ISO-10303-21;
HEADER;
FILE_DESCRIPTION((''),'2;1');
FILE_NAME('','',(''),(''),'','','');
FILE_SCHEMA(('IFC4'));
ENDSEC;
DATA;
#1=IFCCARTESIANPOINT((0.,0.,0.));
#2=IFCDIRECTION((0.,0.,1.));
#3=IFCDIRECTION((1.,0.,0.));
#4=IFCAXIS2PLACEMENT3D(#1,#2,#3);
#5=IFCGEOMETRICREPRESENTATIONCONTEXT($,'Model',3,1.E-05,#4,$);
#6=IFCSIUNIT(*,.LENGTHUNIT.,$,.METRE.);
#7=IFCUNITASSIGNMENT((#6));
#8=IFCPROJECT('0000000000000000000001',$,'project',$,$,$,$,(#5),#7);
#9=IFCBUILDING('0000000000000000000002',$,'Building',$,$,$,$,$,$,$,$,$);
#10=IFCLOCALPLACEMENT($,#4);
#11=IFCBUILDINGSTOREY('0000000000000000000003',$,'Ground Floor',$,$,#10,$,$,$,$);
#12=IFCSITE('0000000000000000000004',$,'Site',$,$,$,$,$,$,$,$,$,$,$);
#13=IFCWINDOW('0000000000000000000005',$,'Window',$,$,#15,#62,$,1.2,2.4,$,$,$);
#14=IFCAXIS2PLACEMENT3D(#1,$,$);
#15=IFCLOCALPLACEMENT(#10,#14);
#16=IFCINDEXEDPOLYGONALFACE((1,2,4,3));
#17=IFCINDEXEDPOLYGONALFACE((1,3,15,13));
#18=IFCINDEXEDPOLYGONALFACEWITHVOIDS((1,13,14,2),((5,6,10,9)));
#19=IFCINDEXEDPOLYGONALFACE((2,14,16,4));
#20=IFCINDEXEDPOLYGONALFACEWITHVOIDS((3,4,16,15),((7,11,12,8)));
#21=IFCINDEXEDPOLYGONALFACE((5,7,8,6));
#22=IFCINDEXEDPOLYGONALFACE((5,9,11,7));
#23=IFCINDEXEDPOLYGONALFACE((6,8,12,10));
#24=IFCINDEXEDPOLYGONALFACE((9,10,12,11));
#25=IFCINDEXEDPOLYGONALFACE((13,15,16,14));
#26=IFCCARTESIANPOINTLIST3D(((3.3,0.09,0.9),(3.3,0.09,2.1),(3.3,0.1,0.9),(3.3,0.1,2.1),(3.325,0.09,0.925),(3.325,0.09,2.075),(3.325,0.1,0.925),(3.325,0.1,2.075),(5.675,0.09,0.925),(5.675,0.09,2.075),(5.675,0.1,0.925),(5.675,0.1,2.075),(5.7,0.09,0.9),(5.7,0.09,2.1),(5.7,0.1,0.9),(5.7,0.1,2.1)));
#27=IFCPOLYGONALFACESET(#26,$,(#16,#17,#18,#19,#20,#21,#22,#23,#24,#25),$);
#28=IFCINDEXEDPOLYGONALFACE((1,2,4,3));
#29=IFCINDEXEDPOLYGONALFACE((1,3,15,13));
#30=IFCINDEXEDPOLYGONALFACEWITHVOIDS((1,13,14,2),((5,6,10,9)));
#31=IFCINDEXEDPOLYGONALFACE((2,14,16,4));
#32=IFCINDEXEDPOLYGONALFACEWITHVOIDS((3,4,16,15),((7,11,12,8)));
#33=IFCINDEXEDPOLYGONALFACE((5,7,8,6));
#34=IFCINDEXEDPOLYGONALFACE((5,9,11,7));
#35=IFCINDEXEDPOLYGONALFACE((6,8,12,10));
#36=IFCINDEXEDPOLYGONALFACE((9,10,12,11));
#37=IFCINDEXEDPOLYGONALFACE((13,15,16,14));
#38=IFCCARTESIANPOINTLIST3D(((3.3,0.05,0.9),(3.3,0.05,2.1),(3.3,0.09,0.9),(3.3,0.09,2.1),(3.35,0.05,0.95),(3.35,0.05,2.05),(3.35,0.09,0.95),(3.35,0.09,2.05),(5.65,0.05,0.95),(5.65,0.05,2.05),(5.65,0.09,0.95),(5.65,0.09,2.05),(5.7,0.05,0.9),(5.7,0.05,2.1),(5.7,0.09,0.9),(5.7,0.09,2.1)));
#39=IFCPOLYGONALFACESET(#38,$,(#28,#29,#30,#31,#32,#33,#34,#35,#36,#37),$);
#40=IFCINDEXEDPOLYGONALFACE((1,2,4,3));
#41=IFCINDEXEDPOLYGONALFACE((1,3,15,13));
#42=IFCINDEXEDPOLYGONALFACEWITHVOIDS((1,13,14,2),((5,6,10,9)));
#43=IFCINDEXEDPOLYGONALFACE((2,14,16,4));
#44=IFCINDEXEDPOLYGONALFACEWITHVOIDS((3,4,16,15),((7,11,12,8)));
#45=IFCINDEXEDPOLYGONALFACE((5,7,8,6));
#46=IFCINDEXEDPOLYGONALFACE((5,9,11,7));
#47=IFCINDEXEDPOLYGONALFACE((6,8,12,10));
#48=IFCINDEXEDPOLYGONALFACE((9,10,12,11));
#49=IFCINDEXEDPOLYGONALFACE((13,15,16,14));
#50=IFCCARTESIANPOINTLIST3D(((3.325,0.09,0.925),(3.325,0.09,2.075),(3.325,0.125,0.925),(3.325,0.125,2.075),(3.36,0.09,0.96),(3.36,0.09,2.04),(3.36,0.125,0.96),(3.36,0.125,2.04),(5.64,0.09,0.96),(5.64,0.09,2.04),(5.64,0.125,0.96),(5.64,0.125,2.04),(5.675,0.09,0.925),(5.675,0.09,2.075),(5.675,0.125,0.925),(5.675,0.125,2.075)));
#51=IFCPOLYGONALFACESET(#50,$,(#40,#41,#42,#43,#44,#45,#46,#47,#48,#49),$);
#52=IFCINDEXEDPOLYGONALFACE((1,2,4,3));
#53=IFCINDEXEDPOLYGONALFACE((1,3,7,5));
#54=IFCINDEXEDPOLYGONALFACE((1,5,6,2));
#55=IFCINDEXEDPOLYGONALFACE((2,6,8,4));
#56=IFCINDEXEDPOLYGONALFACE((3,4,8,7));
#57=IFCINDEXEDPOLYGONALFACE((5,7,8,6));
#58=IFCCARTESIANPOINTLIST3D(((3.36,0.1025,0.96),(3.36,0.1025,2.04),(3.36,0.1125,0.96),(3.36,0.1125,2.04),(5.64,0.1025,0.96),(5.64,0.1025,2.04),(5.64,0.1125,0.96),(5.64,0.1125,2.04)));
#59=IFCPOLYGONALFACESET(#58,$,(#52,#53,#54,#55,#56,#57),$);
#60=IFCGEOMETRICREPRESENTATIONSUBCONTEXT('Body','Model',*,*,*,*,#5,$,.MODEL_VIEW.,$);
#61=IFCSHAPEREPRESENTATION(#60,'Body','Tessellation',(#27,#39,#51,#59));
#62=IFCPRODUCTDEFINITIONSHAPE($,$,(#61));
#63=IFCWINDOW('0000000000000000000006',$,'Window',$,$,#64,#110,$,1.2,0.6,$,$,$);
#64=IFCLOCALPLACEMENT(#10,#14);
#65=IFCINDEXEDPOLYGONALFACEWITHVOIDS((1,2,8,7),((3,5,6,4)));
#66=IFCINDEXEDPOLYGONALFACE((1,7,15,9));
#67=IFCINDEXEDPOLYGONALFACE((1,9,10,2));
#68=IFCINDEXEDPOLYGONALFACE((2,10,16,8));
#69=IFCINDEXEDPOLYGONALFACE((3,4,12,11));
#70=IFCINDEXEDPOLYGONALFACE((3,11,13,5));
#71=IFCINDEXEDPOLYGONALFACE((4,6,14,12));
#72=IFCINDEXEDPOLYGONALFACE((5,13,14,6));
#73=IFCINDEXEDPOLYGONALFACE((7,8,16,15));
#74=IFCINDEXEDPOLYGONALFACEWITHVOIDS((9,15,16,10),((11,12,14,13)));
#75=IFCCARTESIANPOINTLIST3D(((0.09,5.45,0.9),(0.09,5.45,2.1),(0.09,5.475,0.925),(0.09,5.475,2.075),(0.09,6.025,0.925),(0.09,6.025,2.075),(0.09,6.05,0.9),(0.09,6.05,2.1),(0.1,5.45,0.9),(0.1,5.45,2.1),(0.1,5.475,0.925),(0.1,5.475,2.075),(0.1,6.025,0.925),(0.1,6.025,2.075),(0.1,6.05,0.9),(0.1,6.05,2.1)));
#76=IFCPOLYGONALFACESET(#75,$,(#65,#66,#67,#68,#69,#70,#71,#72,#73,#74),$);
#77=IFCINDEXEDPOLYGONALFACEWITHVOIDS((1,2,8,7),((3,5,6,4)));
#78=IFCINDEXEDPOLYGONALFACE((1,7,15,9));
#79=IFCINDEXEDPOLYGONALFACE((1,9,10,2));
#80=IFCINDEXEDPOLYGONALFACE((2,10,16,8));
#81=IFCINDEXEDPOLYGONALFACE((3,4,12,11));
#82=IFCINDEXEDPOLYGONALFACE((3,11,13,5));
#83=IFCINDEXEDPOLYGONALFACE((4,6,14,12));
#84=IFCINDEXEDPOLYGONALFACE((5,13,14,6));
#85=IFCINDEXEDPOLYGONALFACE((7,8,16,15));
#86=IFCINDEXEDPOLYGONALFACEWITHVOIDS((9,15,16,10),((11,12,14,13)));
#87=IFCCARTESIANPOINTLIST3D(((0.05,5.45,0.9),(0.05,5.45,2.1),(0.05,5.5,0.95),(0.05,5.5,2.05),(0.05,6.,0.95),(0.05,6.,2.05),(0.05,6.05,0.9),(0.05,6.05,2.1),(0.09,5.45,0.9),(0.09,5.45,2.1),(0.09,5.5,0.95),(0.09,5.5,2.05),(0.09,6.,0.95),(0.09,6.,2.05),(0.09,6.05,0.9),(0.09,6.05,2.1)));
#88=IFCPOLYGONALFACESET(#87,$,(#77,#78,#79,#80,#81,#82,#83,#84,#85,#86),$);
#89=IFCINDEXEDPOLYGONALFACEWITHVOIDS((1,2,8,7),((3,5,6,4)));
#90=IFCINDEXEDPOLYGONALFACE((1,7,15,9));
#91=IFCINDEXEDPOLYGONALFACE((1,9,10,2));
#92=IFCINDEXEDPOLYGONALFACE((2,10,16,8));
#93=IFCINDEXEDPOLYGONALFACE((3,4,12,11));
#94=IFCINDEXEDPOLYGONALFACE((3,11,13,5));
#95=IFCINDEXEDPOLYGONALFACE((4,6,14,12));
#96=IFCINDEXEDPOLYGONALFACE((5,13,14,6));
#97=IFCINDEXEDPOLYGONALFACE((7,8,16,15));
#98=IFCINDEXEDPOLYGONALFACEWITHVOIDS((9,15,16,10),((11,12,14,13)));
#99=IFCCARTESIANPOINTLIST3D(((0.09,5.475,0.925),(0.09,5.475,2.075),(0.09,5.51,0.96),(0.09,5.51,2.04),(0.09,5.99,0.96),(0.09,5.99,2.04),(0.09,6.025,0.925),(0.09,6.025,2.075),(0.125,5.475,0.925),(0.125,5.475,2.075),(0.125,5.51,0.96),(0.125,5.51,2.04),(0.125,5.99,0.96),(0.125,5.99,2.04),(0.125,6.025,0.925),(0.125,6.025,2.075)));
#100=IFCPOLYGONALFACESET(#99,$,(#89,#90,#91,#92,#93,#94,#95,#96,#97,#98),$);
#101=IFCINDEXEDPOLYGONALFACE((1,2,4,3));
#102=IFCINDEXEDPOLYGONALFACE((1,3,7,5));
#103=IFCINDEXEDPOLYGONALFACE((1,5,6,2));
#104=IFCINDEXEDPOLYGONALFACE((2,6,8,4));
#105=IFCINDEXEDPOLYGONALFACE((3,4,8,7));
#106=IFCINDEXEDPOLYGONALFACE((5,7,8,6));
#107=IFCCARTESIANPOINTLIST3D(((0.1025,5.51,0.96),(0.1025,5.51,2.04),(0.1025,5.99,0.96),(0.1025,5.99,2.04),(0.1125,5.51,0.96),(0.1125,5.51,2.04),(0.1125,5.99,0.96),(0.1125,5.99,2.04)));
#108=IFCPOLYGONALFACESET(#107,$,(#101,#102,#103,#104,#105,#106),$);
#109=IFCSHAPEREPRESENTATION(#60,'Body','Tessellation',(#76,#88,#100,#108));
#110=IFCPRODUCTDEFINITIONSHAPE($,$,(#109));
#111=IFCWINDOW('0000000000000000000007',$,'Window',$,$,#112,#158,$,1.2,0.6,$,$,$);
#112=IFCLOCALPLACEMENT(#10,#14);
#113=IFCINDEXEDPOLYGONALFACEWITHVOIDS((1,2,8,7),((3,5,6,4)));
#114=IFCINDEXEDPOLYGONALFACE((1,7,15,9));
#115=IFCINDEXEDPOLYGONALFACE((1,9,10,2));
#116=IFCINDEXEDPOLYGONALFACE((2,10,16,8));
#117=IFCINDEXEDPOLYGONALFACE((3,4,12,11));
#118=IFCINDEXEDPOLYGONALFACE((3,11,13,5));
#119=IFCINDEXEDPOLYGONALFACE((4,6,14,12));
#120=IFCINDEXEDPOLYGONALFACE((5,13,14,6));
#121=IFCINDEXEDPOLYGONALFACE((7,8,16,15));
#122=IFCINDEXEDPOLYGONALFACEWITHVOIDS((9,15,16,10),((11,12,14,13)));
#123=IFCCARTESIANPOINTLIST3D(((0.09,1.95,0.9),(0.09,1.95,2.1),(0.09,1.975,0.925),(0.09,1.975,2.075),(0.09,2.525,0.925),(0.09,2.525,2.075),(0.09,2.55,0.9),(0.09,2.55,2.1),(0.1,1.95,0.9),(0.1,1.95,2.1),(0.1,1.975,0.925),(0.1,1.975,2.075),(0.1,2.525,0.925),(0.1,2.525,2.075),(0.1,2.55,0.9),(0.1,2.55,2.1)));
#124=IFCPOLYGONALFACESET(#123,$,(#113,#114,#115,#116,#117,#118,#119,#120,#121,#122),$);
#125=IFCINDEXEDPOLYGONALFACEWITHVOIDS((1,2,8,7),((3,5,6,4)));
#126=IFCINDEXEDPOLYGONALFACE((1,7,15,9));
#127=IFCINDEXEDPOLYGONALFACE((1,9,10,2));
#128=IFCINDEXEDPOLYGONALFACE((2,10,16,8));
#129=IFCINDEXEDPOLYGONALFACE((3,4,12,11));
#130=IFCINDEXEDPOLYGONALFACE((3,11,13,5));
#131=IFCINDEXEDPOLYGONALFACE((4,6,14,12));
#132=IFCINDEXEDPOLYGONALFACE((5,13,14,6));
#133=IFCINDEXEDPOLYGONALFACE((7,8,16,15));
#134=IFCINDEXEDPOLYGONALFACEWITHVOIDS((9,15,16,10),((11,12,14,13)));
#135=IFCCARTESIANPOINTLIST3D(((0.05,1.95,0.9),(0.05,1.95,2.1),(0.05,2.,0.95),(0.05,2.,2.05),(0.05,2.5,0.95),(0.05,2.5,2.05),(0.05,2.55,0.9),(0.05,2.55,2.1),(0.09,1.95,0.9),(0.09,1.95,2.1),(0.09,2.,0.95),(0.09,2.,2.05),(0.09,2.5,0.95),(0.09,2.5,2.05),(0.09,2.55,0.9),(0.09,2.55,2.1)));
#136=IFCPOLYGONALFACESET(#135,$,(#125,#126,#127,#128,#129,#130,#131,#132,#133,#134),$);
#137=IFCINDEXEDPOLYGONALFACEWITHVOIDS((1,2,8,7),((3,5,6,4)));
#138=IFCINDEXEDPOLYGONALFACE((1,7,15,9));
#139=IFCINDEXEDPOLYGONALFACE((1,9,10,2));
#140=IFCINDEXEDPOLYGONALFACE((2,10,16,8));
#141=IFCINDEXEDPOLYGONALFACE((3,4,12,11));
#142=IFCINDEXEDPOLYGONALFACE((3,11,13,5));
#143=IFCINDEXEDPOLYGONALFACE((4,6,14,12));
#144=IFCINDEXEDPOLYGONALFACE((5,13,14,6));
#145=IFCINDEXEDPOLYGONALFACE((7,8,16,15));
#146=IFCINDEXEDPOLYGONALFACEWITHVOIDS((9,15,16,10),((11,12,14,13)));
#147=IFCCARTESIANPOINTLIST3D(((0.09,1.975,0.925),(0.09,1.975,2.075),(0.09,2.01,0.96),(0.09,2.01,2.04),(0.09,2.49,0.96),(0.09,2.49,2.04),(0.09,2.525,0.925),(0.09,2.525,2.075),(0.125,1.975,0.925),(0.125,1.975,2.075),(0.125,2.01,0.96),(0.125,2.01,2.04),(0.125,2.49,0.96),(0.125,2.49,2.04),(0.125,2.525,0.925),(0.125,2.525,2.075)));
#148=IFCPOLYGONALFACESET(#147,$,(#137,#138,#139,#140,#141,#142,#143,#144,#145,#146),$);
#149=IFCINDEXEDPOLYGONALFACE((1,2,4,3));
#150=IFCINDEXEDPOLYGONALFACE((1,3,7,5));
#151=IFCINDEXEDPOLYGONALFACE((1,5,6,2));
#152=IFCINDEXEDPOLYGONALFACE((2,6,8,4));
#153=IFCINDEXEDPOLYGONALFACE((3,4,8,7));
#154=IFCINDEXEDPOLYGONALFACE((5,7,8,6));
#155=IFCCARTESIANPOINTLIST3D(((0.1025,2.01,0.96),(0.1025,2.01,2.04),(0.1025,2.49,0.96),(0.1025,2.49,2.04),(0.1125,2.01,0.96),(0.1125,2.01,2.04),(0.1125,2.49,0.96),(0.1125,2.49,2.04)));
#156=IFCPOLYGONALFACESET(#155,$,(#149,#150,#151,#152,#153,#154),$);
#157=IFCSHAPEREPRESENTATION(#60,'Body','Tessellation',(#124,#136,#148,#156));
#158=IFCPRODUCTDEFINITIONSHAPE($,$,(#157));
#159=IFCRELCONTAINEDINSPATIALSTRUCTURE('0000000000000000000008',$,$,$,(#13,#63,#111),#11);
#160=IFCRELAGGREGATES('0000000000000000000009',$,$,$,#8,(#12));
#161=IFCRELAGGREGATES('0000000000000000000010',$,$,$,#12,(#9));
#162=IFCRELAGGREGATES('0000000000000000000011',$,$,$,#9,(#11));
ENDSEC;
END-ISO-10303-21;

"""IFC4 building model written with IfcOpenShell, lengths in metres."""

from ifc_helpers import new_model, si_unit, frame, origin_with_axes, place, context, subcontext, project, spatial, line, indexed_curve, outline, extrude, element, save


model = new_model("IFC4")

# Units and contexts
model_context = context("Model", 3, precision=1e-05, world=origin_with_axes())
body_context = subcontext(model_context, "Body", "Model", "MODEL_VIEW")
ifc_project = project(units=[si_unit("LENGTHUNIT", "METRE")], contexts=[model_context])

# Site, building, storey
site = spatial("IfcSite", under=ifc_project, Name="Site")
building = spatial("IfcBuilding", under=site, Name="Building")
storey_placement = place(None, origin_with_axes())
storey = spatial("IfcBuildingStorey", under=building, at=storey_placement, Name="Ground Floor")

# Windows
window_placement = place(storey_placement, frame((3.3, 0.0, 0.9), z_axis=(0.0, 0.0, 1.0), x_axis=(1.0, 0.0, 0.0)))
element("IfcWindow", 1, at=window_placement, inside=storey, Name="Window", OverallHeight=1.2, OverallWidth=2.4, context=body_context, shape_type="SweptSolid", body=[
    extrude(outline(indexed_curve([(0.0, 0.0), (2.4, 0.0), (2.4, 1.2), (0.0, 1.2)], segments=[line(1, 2, 3, 4, 1)]), holes=[indexed_curve([(0.025, 0.025), (2.375, 0.025), (2.375, 1.175), (0.025, 1.175)], segments=[line(1, 2, 3, 4, 1)])]), frame((0.0, 0.09, 0.0), z_axis=(0.0, -1.0, 0.0), x_axis=(1.0, 0.0, 0.0)), (0.0, 0.0, -1.0), 0.01),
    extrude(outline(indexed_curve([(0.0, 0.0), (2.4, 0.0), (2.4, 1.2), (0.0, 1.2)], segments=[line(1, 2, 3, 4, 1)]), holes=[indexed_curve([(0.05, 0.05), (2.35, 0.05), (2.35, 1.15), (0.05, 1.15)], segments=[line(1, 2, 3, 4, 1)])]), frame((0.0, 0.05, 0.0), z_axis=(0.0, -1.0, 0.0), x_axis=(1.0, 0.0, 0.0)), (0.0, 0.0, -1.0), 0.04),
    extrude(outline(indexed_curve([(0.0, 0.0), (2.35, 0.0), (2.35, 1.15), (0.0, 1.15)], segments=[line(1, 2, 3, 4, 1)]), holes=[indexed_curve([(0.035, 0.035), (2.315, 0.035), (2.315, 1.115), (0.035, 1.115)], segments=[line(1, 2, 3, 4, 1)])]), frame((0.025, 0.09, 0.025), z_axis=(0.0, -1.0, 0.0), x_axis=(1.0, 0.0, 0.0)), (0.0, 0.0, -1.0), 0.035),
    extrude(outline(indexed_curve([(0.035, 0.035), (2.315, 0.035), (2.315, 1.115), (0.035, 1.115)], segments=[line(1, 2, 3, 4, 1)])), frame((0.025, 0.1025, 0.025), z_axis=(0.0, -1.0, 0.0), x_axis=(1.0, 0.0, 0.0)), (0.0, 0.0, -1.0), 0.01),
])
for number, where, z_axis, x_axis, name in (
    (2, (0.0, 6.05, 0.9), (0.0, 0.0, 1.0), (0.0, -1.0, 0.0), "Window"),
    (3, (0.0, 2.55, 0.9), (0.0, 0.0, 1.0), (0.0, -1.0, 0.0), "Window"),
):
    element("IfcWindow", number, at=place(storey_placement, frame(where, z_axis=z_axis, x_axis=x_axis)), inside=storey, Name=name, OverallHeight=1.2, OverallWidth=0.6, context=body_context, shape_type="SweptSolid", body=[
        extrude(outline(indexed_curve([(0.0, 0.0), (0.6, 0.0), (0.6, 1.2), (0.0, 1.2)], segments=[line(1, 2, 3, 4, 1)]), holes=[indexed_curve([(0.025, 0.025), (0.575, 0.025), (0.575, 1.175), (0.025, 1.175)], segments=[line(1, 2, 3, 4, 1)])]), frame((0.0, 0.09, 0.0), z_axis=(0.0, -1.0, 0.0), x_axis=(1.0, 0.0, 0.0)), (0.0, 0.0, -1.0), 0.01),
        extrude(outline(indexed_curve([(0.0, 0.0), (0.6, 0.0), (0.6, 1.2), (0.0, 1.2)], segments=[line(1, 2, 3, 4, 1)]), holes=[indexed_curve([(0.05, 0.05), (0.55, 0.05), (0.55, 1.15), (0.05, 1.15)], segments=[line(1, 2, 3, 4, 1)])]), frame((0.0, 0.05, 0.0), z_axis=(0.0, -1.0, 0.0), x_axis=(1.0, 0.0, 0.0)), (0.0, 0.0, -1.0), 0.04),
        extrude(outline(indexed_curve([(0.0, 0.0), (0.55, 0.0), (0.55, 1.15), (0.0, 1.15)], segments=[line(1, 2, 3, 4, 1)]), holes=[indexed_curve([(0.035, 0.035), (0.515, 0.035), (0.515, 1.115), (0.035, 1.115)], segments=[line(1, 2, 3, 4, 1)])]), frame((0.025, 0.09, 0.025), z_axis=(0.0, -1.0, 0.0), x_axis=(1.0, 0.0, 0.0)), (0.0, 0.0, -1.0), 0.035),
        extrude(outline(indexed_curve([(0.035, 0.035), (0.515, 0.035), (0.515, 1.115), (0.035, 1.115)], segments=[line(1, 2, 3, 4, 1)])), frame((0.025, 0.1025, 0.025), z_axis=(0.0, -1.0, 0.0), x_axis=(1.0, 0.0, 0.0)), (0.0, 0.0, -1.0), 0.01),
    ])

save(model, "model.ifc")
